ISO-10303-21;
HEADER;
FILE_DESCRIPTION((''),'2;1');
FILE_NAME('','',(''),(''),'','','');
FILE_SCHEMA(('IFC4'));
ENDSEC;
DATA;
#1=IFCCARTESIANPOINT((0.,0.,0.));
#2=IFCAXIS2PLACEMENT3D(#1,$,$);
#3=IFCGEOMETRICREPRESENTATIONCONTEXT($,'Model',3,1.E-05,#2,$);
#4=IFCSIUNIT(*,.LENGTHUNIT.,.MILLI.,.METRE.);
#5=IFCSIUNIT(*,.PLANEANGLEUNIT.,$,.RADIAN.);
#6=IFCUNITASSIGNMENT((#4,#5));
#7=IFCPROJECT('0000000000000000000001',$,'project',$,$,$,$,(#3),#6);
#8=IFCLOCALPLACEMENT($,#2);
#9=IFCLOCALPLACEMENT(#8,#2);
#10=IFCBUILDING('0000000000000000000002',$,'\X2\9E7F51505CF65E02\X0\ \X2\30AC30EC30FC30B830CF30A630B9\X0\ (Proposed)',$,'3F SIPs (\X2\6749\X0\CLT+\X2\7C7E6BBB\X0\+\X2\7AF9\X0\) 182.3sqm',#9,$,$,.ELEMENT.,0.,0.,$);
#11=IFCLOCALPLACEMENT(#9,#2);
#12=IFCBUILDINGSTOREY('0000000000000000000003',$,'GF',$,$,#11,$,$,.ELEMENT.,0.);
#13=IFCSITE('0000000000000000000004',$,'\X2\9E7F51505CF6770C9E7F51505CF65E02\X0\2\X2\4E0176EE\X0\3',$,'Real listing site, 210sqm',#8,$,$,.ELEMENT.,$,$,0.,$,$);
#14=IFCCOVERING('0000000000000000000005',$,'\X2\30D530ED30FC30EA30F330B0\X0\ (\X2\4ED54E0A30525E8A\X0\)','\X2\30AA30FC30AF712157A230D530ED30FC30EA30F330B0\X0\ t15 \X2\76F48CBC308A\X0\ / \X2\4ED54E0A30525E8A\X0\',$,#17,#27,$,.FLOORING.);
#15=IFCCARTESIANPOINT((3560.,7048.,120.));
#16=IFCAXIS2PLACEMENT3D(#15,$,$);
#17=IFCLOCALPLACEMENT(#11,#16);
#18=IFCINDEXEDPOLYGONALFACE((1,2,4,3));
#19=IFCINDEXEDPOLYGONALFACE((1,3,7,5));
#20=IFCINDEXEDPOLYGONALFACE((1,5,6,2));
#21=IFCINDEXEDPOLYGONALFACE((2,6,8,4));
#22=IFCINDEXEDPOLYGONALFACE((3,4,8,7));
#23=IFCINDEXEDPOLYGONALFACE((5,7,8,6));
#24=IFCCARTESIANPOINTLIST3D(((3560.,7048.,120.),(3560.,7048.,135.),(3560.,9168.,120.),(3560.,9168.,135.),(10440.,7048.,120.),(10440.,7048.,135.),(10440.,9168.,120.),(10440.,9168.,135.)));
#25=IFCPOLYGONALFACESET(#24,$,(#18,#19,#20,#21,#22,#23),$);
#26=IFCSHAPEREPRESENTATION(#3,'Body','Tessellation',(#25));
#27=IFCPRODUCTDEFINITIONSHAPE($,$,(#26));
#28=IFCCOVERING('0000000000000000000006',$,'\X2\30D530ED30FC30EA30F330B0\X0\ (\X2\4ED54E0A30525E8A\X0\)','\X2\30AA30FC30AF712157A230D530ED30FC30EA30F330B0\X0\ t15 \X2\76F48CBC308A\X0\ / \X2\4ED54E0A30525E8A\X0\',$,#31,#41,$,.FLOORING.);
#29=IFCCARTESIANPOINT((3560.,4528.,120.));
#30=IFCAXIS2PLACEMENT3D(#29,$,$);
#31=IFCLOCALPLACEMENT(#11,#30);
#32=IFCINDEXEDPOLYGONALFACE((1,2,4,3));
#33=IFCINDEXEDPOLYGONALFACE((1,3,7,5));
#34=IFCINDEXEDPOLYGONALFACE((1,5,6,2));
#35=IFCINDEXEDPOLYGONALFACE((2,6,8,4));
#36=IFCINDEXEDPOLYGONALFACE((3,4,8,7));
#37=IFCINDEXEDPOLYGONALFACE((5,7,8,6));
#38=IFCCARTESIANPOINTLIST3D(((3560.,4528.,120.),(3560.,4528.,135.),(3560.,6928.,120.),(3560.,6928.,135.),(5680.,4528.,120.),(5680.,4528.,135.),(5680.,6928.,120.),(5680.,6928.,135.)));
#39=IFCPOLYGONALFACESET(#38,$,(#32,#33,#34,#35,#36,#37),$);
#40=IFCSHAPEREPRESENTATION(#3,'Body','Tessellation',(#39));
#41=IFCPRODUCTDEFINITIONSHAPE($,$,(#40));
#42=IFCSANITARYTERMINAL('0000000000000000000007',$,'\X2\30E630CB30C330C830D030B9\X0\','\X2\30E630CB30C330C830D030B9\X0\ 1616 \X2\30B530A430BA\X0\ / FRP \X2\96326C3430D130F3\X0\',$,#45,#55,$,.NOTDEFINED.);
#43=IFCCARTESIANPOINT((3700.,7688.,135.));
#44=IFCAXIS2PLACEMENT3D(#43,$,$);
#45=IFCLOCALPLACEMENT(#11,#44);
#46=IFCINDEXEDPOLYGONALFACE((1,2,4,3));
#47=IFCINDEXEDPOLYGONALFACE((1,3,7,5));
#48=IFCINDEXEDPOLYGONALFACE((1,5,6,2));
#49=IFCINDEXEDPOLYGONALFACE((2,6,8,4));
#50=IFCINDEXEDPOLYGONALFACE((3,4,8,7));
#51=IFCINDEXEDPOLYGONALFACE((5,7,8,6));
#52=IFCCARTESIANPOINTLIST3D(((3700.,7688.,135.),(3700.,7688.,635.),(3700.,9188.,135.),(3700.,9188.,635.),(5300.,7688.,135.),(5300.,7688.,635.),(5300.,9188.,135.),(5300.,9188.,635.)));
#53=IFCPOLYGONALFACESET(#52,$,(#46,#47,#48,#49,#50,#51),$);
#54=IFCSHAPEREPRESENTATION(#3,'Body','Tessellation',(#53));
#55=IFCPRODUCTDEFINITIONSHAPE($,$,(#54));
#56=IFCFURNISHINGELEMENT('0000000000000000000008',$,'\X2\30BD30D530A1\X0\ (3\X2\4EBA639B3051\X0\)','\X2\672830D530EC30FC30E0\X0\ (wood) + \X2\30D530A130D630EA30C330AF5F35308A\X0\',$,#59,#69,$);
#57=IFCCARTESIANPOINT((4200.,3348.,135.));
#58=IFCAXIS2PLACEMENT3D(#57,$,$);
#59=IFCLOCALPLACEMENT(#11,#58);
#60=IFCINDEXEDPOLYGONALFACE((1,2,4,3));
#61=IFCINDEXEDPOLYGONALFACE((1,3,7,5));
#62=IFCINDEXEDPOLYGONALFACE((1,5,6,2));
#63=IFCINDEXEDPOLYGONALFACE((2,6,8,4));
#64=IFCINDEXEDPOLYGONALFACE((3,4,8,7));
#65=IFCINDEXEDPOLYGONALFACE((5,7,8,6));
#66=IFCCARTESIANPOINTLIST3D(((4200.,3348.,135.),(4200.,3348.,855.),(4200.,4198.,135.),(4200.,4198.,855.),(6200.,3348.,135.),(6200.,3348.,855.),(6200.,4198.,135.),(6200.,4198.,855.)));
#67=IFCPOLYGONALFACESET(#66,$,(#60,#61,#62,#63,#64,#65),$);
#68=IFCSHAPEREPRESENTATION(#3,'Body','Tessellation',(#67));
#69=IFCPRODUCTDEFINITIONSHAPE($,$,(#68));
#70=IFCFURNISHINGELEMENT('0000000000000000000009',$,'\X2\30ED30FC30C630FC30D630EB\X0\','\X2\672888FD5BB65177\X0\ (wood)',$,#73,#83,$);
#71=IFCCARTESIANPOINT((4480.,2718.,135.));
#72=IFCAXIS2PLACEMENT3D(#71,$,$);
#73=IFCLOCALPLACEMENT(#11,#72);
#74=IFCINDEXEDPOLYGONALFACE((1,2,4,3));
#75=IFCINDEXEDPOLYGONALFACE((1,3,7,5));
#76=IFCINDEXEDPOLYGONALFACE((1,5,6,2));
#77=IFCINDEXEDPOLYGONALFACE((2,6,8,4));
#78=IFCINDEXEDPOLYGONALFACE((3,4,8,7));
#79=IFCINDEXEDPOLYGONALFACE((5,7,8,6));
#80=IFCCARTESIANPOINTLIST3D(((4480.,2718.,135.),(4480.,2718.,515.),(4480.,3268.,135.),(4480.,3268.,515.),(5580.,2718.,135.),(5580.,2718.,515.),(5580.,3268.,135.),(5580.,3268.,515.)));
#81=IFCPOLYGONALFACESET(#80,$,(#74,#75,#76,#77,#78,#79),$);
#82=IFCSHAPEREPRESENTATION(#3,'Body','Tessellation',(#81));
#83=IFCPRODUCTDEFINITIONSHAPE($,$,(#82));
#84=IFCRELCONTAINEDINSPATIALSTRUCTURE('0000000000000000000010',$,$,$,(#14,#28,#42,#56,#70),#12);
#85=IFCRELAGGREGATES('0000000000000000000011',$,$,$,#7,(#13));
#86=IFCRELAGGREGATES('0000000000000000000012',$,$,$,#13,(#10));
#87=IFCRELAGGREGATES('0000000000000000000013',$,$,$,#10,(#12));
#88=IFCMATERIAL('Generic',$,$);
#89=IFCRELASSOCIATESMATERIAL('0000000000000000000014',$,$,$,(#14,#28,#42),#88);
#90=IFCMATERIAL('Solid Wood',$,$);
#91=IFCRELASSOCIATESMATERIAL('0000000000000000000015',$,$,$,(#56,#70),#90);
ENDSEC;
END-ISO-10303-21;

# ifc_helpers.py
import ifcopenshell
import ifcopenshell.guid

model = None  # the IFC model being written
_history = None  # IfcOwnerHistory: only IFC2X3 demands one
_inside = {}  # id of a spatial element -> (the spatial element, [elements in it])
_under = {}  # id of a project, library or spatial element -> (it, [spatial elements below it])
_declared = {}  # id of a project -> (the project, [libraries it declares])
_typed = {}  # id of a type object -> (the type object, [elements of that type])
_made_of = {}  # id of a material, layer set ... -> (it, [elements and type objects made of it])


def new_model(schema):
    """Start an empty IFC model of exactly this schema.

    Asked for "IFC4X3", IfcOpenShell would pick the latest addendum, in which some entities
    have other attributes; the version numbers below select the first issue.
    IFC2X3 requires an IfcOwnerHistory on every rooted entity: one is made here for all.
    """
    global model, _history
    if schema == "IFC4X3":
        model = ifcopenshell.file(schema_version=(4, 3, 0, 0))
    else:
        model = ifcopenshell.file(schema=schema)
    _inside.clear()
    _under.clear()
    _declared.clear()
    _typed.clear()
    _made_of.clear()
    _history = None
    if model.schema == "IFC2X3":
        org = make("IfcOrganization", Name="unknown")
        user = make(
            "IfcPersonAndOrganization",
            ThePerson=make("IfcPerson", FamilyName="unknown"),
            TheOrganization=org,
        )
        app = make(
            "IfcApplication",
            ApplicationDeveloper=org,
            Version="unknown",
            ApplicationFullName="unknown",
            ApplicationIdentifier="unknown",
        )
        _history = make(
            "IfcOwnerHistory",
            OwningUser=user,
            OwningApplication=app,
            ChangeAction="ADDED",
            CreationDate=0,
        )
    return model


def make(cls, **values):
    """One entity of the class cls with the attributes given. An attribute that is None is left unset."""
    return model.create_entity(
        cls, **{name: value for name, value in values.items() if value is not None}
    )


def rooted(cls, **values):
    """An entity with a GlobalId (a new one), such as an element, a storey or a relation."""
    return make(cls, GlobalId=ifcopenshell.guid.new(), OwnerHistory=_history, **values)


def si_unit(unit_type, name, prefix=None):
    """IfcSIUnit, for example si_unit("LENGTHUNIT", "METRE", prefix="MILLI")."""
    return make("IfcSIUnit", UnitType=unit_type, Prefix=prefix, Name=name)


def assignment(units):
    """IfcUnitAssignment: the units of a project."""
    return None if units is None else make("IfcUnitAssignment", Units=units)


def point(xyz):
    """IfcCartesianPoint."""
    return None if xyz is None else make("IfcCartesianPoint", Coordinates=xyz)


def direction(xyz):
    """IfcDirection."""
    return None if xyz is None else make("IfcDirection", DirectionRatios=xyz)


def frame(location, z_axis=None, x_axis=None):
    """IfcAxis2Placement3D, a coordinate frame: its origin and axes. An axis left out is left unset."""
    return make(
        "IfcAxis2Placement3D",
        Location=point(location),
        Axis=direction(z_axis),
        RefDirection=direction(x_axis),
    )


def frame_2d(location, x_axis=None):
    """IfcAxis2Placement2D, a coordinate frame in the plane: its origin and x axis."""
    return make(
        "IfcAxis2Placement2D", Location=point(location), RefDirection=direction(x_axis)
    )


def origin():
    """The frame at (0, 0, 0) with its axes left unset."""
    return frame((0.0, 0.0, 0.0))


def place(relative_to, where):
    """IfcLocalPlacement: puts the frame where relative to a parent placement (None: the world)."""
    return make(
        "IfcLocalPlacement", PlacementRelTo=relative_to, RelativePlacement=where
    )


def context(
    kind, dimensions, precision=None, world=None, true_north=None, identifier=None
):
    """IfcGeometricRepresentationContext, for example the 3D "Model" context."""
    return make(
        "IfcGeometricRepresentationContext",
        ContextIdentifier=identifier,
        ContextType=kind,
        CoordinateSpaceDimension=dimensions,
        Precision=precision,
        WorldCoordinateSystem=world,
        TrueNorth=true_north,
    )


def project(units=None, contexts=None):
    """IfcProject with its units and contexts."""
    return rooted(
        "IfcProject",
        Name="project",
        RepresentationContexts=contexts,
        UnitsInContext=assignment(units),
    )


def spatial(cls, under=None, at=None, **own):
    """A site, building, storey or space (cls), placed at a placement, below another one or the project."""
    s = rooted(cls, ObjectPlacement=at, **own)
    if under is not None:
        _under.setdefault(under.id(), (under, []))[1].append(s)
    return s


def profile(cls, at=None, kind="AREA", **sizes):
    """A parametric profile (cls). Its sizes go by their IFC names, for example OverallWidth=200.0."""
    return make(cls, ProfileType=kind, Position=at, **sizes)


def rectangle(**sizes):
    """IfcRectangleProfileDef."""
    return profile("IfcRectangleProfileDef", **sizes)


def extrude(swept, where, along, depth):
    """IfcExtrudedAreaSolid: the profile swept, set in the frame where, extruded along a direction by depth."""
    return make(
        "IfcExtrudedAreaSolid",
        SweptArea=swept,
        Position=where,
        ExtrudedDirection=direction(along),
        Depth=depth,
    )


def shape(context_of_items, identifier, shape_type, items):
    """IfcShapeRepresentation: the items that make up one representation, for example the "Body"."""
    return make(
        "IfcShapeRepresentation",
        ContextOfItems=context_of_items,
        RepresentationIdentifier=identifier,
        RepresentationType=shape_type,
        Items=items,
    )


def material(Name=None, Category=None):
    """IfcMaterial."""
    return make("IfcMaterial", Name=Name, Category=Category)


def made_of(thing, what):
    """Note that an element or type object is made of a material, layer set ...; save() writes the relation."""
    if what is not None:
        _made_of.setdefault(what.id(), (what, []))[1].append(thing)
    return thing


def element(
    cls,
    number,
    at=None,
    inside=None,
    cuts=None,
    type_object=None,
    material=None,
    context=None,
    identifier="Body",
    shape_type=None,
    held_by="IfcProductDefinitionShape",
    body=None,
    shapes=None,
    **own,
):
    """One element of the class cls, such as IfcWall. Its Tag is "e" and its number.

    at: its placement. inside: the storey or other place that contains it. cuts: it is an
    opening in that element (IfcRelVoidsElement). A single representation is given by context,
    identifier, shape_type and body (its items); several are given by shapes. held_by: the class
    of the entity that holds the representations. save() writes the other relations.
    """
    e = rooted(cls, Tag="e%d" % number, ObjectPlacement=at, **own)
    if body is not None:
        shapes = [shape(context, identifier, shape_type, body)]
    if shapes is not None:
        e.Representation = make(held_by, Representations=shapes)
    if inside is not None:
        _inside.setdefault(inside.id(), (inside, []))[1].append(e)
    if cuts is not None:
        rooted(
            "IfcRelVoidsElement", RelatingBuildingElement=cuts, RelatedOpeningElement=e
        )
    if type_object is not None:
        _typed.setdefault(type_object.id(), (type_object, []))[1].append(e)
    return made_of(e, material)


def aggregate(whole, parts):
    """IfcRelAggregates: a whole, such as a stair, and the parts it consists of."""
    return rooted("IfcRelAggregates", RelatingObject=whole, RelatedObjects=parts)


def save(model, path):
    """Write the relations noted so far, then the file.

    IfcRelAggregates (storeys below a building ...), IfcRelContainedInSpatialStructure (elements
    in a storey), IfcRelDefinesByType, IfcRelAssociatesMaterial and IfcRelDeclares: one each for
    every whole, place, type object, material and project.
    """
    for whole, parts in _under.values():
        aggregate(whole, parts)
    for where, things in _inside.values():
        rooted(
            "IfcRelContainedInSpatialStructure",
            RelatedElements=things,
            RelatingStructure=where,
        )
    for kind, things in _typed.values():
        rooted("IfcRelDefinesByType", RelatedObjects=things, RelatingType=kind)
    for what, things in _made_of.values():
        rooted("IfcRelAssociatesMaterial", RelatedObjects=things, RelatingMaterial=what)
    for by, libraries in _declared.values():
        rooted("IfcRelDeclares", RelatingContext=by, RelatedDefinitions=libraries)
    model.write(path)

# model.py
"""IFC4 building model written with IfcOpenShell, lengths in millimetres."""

from ifc_helpers import new_model, si_unit, frame, frame_2d, origin, place, context, project, spatial, rectangle, extrude, material, element, save


model = new_model("IFC4")

# Units and contexts
model_context = context("Model", 3, precision=1e-05, world=origin())
ifc_project = project(units=[si_unit("LENGTHUNIT", "METRE", prefix="MILLI"), si_unit("PLANEANGLEUNIT", "RADIAN")], contexts=[model_context])

# Site, building, storey
site_placement = place(None, origin())
site = spatial("IfcSite", under=ifc_project, at=site_placement, Name="鹿児島県鹿児島市2丁目3", ObjectType="Real listing site, 210sqm", CompositionType="ELEMENT", RefElevation=0.0)
building_placement = place(site_placement, origin())
building = spatial("IfcBuilding", under=site, at=building_placement, Name="鹿児島市 ガレージハウス (Proposed)", ObjectType="3F SIPs (杉CLT+籾殻+竹) 182.3sqm", CompositionType="ELEMENT", ElevationOfRefHeight=0.0, ElevationOfTerrain=0.0)
storey_placement = place(building_placement, origin())
storey = spatial("IfcBuildingStorey", under=building, at=storey_placement, Name="GF", CompositionType="ELEMENT", Elevation=0.0)

# Shared definitions
ifc_material_1 = material(Name="Solid Wood")

# Coverings
ifc_material_2 = material(Name="Generic")
covering_1_placement = place(storey_placement, frame((3560.0, 7048.0, 120.0)))
element("IfcCovering", 1, at=covering_1_placement, inside=storey, material=ifc_material_2, Name="フローリング (仕上げ床)", Description="オーク無垢フローリング t15 直貼り / 仕上げ床", PredefinedType="FLOORING", context=model_context, shape_type="SweptSolid", body=[
    extrude(rectangle(XDim=6880.0, YDim=2120.0, at=frame_2d((3440.0, 1060.0))), frame((3560.0, 7048.0, 120.0)), (0.0, 0.0, 1.0), 15.0),
])
covering_2_placement = place(storey_placement, frame((3560.0, 4528.0, 120.0)))
element("IfcCovering", 2, at=covering_2_placement, inside=storey, material=ifc_material_2, Name="フローリング (仕上げ床)", Description="オーク無垢フローリング t15 直貼り / 仕上げ床", PredefinedType="FLOORING", context=model_context, shape_type="SweptSolid", body=[
    extrude(rectangle(XDim=2120.0, YDim=2400.0, at=frame_2d((1060.0, 1200.0))), frame((3560.0, 4528.0, 120.0)), (0.0, 0.0, 1.0), 15.0),
])

# Sanitary terminal
sanitary_terminal_placement = place(storey_placement, frame((3700.0, 7688.0, 135.0)))
element("IfcSanitaryTerminal", 3, at=sanitary_terminal_placement, inside=storey, material=ifc_material_2, Name="ユニットバス", Description="ユニットバス 1616 サイズ / FRP 防水パン", PredefinedType="NOTDEFINED", context=model_context, shape_type="SweptSolid", body=[
    extrude(rectangle(XDim=1600.0, YDim=1500.0, at=frame_2d((800.0, 750.0))), frame((3700.0, 7688.0, 135.0)), (0.0, 0.0, 1.0), 500.0),
])

# Furnishing elements
furnishing_1_placement = place(storey_placement, frame((4200.0, 3348.0, 135.0)))
element("IfcFurnishingElement", 4, at=furnishing_1_placement, inside=storey, material=ifc_material_1, Name="ソファ (3人掛け)", Description="木フレーム (wood) + ファブリック張り", context=model_context, shape_type="SweptSolid", body=[
    extrude(rectangle(XDim=2000.0, YDim=850.0, at=frame_2d((1000.0, 425.0))), frame((4200.0, 3348.0, 135.0)), (0.0, 0.0, 1.0), 720.0),
])
furnishing_2_placement = place(storey_placement, frame((4480.0, 2718.0, 135.0)))
element("IfcFurnishingElement", 5, at=furnishing_2_placement, inside=storey, material=ifc_material_1, Name="ローテーブル", Description="木製家具 (wood)", context=model_context, shape_type="SweptSolid", body=[
    extrude(rectangle(XDim=1100.0, YDim=550.0, at=frame_2d((550.0, 275.0))), frame((4480.0, 2718.0, 135.0)), (0.0, 0.0, 1.0), 380.0),
])

save(model, "model.ifc")
